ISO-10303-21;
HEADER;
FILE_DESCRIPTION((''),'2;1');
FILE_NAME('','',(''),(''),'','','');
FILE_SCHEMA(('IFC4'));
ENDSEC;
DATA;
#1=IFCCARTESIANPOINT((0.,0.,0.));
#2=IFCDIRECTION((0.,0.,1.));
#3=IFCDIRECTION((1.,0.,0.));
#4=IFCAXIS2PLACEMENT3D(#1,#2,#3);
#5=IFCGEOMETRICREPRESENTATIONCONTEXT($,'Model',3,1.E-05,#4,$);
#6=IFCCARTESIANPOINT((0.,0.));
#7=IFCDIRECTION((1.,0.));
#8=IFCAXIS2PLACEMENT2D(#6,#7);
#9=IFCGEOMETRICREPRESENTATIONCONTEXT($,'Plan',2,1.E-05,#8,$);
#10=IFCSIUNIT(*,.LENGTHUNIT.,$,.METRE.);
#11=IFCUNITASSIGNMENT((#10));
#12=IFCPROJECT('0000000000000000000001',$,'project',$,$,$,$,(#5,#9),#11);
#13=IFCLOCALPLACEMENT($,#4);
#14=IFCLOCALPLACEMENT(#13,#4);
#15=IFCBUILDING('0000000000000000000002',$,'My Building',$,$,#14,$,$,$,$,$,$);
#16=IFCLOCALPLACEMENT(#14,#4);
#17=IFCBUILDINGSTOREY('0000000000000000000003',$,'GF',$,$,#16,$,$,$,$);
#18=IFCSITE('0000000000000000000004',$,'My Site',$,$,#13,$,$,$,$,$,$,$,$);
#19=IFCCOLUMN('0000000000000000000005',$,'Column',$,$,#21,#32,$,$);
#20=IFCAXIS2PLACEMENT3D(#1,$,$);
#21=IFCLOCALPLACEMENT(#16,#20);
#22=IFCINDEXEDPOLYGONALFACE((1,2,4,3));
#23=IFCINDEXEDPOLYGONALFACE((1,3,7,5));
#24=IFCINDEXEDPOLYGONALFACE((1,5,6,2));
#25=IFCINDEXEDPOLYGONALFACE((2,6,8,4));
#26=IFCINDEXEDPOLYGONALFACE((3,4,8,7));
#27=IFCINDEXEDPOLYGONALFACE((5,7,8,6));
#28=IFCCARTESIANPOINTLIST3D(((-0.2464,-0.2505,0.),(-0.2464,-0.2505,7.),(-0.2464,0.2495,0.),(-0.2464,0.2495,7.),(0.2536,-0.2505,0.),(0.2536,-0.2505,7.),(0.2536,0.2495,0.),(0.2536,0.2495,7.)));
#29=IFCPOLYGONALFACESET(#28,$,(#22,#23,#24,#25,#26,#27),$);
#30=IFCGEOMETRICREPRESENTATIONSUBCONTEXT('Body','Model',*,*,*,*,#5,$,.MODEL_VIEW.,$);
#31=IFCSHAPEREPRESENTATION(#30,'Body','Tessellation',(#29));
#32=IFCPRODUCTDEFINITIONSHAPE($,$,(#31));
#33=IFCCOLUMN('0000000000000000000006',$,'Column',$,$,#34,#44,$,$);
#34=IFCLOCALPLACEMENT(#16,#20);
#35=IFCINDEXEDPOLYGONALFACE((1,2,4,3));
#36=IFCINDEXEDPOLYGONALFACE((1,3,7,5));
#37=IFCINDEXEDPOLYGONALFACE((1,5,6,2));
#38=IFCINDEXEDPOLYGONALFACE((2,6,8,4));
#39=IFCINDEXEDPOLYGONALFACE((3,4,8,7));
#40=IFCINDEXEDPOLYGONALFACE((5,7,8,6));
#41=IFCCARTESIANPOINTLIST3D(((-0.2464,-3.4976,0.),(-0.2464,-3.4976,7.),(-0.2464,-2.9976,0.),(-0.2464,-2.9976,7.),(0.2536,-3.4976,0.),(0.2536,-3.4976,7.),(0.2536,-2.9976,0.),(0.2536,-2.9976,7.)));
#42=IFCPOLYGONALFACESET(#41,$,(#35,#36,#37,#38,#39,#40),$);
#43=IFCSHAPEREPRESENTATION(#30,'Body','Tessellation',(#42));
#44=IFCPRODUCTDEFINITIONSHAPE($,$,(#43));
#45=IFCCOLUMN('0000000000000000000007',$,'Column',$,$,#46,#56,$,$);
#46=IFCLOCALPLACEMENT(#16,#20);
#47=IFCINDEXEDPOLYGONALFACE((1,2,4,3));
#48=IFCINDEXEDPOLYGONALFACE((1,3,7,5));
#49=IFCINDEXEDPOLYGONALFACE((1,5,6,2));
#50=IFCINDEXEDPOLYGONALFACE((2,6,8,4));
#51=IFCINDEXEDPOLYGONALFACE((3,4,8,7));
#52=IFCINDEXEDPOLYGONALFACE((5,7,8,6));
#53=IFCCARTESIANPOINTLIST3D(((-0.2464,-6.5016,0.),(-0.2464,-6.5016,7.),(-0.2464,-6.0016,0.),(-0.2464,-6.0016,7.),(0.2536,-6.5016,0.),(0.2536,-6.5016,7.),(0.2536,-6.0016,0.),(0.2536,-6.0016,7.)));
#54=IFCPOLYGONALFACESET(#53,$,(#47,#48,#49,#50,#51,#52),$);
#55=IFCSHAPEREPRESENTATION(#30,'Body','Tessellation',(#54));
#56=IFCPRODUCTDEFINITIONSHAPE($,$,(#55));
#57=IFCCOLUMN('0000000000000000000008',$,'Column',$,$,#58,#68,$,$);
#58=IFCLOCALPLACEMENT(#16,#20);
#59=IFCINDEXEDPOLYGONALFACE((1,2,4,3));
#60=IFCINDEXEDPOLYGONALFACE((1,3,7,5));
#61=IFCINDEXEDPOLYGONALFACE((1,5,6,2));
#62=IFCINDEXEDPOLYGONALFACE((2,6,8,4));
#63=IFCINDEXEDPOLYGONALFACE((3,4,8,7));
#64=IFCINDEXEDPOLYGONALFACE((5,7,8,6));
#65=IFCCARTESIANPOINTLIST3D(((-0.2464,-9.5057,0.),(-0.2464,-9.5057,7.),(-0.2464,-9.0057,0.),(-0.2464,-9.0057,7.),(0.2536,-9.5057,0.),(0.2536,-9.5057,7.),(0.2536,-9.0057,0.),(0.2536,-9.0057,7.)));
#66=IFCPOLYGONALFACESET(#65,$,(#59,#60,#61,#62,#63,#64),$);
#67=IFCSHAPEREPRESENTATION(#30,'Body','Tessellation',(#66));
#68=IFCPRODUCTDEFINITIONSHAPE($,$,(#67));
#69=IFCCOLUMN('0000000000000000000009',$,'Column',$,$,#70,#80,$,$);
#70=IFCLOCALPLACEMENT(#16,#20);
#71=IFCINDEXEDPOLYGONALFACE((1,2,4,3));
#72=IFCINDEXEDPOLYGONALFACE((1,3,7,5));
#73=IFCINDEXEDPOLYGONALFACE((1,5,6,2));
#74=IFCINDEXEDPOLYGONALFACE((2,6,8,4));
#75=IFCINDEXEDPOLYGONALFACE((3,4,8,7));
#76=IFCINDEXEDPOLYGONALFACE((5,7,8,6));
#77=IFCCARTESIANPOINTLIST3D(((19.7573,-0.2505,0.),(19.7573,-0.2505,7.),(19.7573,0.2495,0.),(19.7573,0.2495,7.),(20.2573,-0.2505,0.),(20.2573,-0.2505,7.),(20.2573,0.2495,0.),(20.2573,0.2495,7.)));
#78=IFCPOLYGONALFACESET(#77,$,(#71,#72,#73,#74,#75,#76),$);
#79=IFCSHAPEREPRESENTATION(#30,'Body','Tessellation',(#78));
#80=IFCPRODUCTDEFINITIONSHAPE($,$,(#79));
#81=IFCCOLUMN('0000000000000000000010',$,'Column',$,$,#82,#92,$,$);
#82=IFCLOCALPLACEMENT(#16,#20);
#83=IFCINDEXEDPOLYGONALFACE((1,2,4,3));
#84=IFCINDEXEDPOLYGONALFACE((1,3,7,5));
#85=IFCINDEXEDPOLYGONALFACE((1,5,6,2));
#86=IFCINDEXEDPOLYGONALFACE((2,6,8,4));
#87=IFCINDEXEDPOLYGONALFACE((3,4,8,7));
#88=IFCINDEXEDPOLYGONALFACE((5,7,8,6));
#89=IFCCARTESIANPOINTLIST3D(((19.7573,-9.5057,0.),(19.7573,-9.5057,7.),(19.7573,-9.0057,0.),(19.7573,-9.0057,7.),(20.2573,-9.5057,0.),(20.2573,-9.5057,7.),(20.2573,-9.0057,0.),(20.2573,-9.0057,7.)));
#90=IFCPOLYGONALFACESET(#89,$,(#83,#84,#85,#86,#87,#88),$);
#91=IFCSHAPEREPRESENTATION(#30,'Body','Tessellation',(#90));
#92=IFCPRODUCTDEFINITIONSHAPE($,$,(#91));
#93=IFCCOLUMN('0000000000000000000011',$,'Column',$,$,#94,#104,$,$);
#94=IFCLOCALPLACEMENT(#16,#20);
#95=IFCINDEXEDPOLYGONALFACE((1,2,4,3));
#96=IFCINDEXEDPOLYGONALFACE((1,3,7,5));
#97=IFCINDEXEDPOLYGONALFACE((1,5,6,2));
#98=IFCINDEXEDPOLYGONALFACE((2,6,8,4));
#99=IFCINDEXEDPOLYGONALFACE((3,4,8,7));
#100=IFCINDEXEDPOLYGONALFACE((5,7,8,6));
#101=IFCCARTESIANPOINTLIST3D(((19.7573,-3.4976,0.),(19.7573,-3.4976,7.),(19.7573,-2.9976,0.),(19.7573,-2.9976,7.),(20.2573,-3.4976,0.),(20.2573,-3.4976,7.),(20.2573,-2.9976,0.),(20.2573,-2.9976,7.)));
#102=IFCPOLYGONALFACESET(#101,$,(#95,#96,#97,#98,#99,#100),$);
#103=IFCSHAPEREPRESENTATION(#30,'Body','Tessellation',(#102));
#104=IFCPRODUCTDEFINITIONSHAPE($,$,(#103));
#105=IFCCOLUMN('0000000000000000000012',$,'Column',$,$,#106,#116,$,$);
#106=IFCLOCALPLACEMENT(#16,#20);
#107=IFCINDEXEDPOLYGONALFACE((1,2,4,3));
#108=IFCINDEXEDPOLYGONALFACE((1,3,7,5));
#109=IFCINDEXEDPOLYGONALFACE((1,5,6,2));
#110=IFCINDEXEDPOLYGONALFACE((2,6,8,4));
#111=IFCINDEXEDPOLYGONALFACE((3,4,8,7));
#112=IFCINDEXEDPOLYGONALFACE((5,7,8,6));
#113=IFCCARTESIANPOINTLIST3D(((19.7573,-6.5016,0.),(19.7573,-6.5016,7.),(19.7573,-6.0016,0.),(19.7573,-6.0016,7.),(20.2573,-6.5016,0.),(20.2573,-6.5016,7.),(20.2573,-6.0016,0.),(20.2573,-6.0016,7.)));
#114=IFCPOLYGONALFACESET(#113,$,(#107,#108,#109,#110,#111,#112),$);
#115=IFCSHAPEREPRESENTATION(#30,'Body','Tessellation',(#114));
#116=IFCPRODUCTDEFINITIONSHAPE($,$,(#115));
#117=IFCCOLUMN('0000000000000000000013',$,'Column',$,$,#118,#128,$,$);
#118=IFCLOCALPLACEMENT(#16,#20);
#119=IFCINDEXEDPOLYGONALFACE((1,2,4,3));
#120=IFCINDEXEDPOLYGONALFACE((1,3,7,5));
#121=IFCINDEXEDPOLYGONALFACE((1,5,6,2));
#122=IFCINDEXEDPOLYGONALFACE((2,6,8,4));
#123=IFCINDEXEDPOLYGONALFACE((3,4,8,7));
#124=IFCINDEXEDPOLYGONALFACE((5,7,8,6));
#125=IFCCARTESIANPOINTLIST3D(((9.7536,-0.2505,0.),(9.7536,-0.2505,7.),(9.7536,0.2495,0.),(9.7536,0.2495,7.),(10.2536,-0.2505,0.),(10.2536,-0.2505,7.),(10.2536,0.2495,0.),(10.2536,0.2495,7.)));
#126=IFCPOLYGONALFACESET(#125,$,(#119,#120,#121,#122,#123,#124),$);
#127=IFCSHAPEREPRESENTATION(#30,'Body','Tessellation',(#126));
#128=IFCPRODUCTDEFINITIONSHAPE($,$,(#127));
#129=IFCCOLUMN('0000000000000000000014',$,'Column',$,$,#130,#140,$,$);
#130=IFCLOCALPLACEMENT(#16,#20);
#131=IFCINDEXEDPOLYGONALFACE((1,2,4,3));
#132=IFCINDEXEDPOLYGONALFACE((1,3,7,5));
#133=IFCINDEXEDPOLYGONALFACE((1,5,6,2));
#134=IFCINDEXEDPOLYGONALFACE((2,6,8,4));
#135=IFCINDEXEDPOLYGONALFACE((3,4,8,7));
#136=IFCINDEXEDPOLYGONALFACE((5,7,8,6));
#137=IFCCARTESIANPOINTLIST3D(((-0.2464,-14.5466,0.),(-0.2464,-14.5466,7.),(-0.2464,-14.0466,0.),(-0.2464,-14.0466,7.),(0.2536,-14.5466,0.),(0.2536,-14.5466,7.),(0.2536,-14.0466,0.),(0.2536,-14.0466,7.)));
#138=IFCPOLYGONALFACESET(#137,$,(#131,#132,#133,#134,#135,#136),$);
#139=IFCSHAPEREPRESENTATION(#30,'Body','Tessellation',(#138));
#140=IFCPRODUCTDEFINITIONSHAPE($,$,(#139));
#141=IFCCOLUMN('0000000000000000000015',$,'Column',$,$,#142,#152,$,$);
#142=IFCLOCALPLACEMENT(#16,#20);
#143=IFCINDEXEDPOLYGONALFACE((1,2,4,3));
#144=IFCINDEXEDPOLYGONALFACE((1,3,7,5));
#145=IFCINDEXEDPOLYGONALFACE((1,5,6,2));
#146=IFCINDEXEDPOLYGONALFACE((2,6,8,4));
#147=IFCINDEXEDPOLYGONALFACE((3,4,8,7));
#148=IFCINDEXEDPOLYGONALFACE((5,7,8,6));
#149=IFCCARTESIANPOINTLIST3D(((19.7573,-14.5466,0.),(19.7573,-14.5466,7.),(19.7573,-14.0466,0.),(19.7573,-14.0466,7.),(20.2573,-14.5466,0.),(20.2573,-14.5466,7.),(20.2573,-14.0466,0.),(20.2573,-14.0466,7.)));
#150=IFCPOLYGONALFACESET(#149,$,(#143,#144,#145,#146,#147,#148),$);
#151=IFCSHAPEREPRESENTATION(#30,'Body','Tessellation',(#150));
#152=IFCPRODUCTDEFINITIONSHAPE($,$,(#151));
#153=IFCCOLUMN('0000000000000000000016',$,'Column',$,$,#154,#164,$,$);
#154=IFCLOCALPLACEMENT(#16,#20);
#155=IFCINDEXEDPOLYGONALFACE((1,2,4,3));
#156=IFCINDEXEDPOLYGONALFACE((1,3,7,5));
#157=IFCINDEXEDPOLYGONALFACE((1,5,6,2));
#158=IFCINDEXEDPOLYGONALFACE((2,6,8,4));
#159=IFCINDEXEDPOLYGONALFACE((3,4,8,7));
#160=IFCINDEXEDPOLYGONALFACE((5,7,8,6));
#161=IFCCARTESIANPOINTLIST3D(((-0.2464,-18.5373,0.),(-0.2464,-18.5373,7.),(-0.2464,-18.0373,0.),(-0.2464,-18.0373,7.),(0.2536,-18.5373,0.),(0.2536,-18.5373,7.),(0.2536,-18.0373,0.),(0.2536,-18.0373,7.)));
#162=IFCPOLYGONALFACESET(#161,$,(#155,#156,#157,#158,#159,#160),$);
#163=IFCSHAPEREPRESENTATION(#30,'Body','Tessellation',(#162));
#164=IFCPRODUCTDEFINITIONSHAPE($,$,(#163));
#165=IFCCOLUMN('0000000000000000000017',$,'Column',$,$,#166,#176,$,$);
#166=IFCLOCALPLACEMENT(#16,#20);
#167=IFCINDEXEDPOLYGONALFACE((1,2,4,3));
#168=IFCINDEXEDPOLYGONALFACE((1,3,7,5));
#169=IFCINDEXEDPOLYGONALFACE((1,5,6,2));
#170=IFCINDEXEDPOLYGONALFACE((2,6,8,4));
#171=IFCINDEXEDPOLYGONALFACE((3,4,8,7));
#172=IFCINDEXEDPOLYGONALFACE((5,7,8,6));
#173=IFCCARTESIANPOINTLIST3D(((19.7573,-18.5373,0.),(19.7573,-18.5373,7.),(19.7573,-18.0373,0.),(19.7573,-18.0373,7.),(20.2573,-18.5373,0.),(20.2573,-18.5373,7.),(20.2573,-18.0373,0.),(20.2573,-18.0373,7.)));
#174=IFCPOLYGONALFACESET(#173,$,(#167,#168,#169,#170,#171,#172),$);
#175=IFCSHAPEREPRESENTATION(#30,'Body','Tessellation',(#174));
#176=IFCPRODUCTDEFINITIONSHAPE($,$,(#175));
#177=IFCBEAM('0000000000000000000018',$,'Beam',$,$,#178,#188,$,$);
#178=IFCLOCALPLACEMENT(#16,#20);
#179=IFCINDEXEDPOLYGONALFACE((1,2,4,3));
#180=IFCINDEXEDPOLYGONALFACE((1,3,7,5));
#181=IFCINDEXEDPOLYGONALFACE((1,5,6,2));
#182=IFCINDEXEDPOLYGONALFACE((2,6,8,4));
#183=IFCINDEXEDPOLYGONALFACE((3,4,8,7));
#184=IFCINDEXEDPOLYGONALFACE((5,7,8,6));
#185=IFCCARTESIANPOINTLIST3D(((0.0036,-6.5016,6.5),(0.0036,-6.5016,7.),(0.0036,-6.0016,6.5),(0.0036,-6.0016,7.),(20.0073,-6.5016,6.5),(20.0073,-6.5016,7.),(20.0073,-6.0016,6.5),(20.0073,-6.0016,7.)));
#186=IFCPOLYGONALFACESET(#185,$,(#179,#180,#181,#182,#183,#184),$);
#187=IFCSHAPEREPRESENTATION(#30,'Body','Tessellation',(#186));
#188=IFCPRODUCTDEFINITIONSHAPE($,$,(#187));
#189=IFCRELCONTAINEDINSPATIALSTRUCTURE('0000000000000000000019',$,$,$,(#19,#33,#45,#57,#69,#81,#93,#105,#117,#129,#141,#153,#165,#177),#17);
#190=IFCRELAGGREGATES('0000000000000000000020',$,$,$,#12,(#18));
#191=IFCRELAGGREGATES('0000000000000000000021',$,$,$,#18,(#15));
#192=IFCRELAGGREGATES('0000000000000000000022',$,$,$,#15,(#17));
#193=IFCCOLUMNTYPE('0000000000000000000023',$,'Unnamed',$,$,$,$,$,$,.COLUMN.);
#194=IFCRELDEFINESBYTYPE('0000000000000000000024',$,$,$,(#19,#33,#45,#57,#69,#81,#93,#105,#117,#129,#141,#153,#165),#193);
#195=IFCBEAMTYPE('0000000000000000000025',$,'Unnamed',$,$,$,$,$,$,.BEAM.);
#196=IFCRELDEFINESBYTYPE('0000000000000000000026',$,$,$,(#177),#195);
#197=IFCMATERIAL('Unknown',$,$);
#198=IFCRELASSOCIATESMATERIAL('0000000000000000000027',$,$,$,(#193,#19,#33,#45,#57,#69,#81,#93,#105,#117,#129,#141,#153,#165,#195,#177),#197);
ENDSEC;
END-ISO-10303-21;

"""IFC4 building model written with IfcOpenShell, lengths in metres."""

from ifc_helpers import new_model, si_unit, frame, origin_with_axes, origin_2d_with_axis, place, context, subcontext, project, spatial, rectangle, extrude, material, material_profile, profile_set, profile_usage, type_object, element, save


model = new_model("IFC4")

# Units and contexts
model_context = context("Model", 3, precision=1e-05, world=origin_with_axes())
plan_context = context("Plan", 2, precision=1e-05, world=origin_2d_with_axis())
body_context_1 = subcontext(model_context, "Body", "Model", "MODEL_VIEW")
ifc_project = project(units=[si_unit("LENGTHUNIT", "METRE")], contexts=[model_context, plan_context])

# Site, building, storey
site_placement = place(None, origin_with_axes())
site = spatial("IfcSite", under=ifc_project, at=site_placement, Name="My Site")
building_placement = place(site_placement, origin_with_axes())
building = spatial("IfcBuilding", under=site, at=building_placement, Name="My Building")
storey_placement = place(building_placement, origin_with_axes())
storey = spatial("IfcBuildingStorey", under=building, at=storey_placement, Name="GF")

# Columns
ifc_material = material(Name="Unknown")
ifc_material_profile_1 = material_profile(ifc_material, rectangle(XDim=0.5, YDim=0.5))
ifc_profile_set_1 = profile_set([ifc_material_profile_1])
ifc_profile_usage_1 = profile_usage(ifc_profile_set_1, cardinal=5)
column_type = type_object("IfcColumnType", Name="Unnamed", PredefinedType="COLUMN", material=ifc_profile_set_1)
column_1_placement = place(storey_placement, frame((0.0036, -0.0005, 0.0), z_axis=(0.0, 0.0, 1.0), x_axis=(1.0, 0.0, 0.0)))
element("IfcColumn", 1, at=column_1_placement, inside=storey, type_object=column_type, material=ifc_profile_usage_1, Name="Column", context=body_context_1, shape_type="SweptSolid", body=[
    extrude(rectangle(XDim=0.5, YDim=0.5), origin_with_axes(), (0.0, 0.0, 1.0), 7.0),
])
ifc_profile_usage_2 = profile_usage(ifc_profile_set_1, cardinal=5)
column_2_placement = place(storey_placement, frame((0.0036, -3.2476, 0.0), z_axis=(0.0, 0.0, 1.0), x_axis=(1.0, 0.0, 0.0)))
element("IfcColumn", 2, at=column_2_placement, inside=storey, type_object=column_type, material=ifc_profile_usage_2, Name="Column", context=body_context_1, shape_type="SweptSolid", body=[
    extrude(rectangle(XDim=0.5, YDim=0.5), origin_with_axes(), (0.0, 0.0, 1.0), 7.0),
])
ifc_profile_usage_3 = profile_usage(ifc_profile_set_1, cardinal=5)
column_3_placement = place(storey_placement, frame((0.0036, -6.2516, 0.0), z_axis=(0.0, 0.0, 1.0), x_axis=(1.0, 0.0, 0.0)))
element("IfcColumn", 3, at=column_3_placement, inside=storey, type_object=column_type, material=ifc_profile_usage_3, Name="Column", context=body_context_1, shape_type="SweptSolid", body=[
    extrude(rectangle(XDim=0.5, YDim=0.5), origin_with_axes(), (0.0, 0.0, 1.0), 7.0),
])
ifc_profile_usage_4 = profile_usage(ifc_profile_set_1, cardinal=5)
column_4_placement = place(storey_placement, frame((0.0036, -9.2557, 0.0), z_axis=(0.0, 0.0, 1.0), x_axis=(1.0, 0.0, 0.0)))
element("IfcColumn", 4, at=column_4_placement, inside=storey, type_object=column_type, material=ifc_profile_usage_4, Name="Column", context=body_context_1, shape_type="SweptSolid", body=[
    extrude(rectangle(XDim=0.5, YDim=0.5), origin_with_axes(), (0.0, 0.0, 1.0), 7.0),
])
ifc_profile_usage_5 = profile_usage(ifc_profile_set_1, cardinal=5)
column_5_placement = place(storey_placement, frame((20.0073, -0.0005, 0.0), z_axis=(0.0, 0.0, 1.0), x_axis=(1.0, 0.0, 0.0)))
element("IfcColumn", 5, at=column_5_placement, inside=storey, type_object=column_type, material=ifc_profile_usage_5, Name="Column", context=body_context_1, shape_type="SweptSolid", body=[
    extrude(rectangle(XDim=0.5, YDim=0.5), origin_with_axes(), (0.0, 0.0, 1.0), 7.0),
])
ifc_profile_usage_6 = profile_usage(ifc_profile_set_1, cardinal=5)
column_6_placement = place(storey_placement, frame((20.0073, -9.2557, 0.0), z_axis=(0.0, 0.0, 1.0), x_axis=(1.0, 0.0, 0.0)))
element("IfcColumn", 6, at=column_6_placement, inside=storey, type_object=column_type, material=ifc_profile_usage_6, Name="Column", context=body_context_1, shape_type="SweptSolid", body=[
    extrude(rectangle(XDim=0.5, YDim=0.5), origin_with_axes(), (0.0, 0.0, 1.0), 7.0),
])
ifc_profile_usage_7 = profile_usage(ifc_profile_set_1, cardinal=5)
column_7_placement = place(storey_placement, frame((20.0073, -3.2476, 0.0), z_axis=(0.0, 0.0, 1.0), x_axis=(1.0, 0.0, 0.0)))
element("IfcColumn", 7, at=column_7_placement, inside=storey, type_object=column_type, material=ifc_profile_usage_7, Name="Column", context=body_context_1, shape_type="SweptSolid", body=[
    extrude(rectangle(XDim=0.5, YDim=0.5), origin_with_axes(), (0.0, 0.0, 1.0), 7.0),
])
ifc_profile_usage_8 = profile_usage(ifc_profile_set_1, cardinal=5)
column_8_placement = place(storey_placement, frame((20.0073, -6.2516, 0.0), z_axis=(0.0, 0.0, 1.0), x_axis=(1.0, 0.0, 0.0)))
element("IfcColumn", 8, at=column_8_placement, inside=storey, type_object=column_type, material=ifc_profile_usage_8, Name="Column", context=body_context_1, shape_type="SweptSolid", body=[
    extrude(rectangle(XDim=0.5, YDim=0.5), origin_with_axes(), (0.0, 0.0, 1.0), 7.0),
])
ifc_profile_usage_9 = profile_usage(ifc_profile_set_1, cardinal=5)
column_9_placement = place(storey_placement, frame((10.0036, -0.0005, 0.0), z_axis=(0.0, 0.0, 1.0), x_axis=(1.0, 0.0, 0.0)))
element("IfcColumn", 9, at=column_9_placement, inside=storey, type_object=column_type, material=ifc_profile_usage_9, Name="Column", context=body_context_1, shape_type="SweptSolid", body=[
    extrude(rectangle(XDim=0.5, YDim=0.5), origin_with_axes(), (0.0, 0.0, 1.0), 7.0),
])
ifc_profile_usage_10 = profile_usage(ifc_profile_set_1, cardinal=5)
column_10_placement = place(storey_placement, frame((0.0036, -14.2966, 0.0), z_axis=(0.0, 0.0, 1.0), x_axis=(1.0, 0.0, 0.0)))
element("IfcColumn", 10, at=column_10_placement, inside=storey, type_object=column_type, material=ifc_profile_usage_10, Name="Column", context=body_context_1, shape_type="SweptSolid", body=[
    extrude(rectangle(XDim=0.5, YDim=0.5), origin_with_axes(), (0.0, 0.0, 1.0), 7.0),
])
ifc_profile_usage_11 = profile_usage(ifc_profile_set_1, cardinal=5)
column_11_placement = place(storey_placement, frame((20.0073, -14.2966, 0.0), z_axis=(0.0, 0.0, 1.0), x_axis=(1.0, 0.0, 0.0)))
element("IfcColumn", 11, at=column_11_placement, inside=storey, type_object=column_type, material=ifc_profile_usage_11, Name="Column", context=body_context_1, shape_type="SweptSolid", body=[
    extrude(rectangle(XDim=0.5, YDim=0.5), origin_with_axes(), (0.0, 0.0, 1.0), 7.0),
])
ifc_profile_usage_12 = profile_usage(ifc_profile_set_1, cardinal=5)
column_12_placement = place(storey_placement, frame((0.0036, -18.2873, 0.0), z_axis=(0.0, 0.0, 1.0), x_axis=(1.0, 0.0, 0.0)))
element("IfcColumn", 12, at=column_12_placement, inside=storey, type_object=column_type, material=ifc_profile_usage_12, Name="Column", context=body_context_1, shape_type="SweptSolid", body=[
    extrude(rectangle(XDim=0.5, YDim=0.5), origin_with_axes(), (0.0, 0.0, 1.0), 7.0),
])
ifc_profile_usage_13 = profile_usage(ifc_profile_set_1, cardinal=5)
column_13_placement = place(storey_placement, frame((20.0073, -18.2873, 0.0), z_axis=(0.0, 0.0, 1.0), x_axis=(1.0, 0.0, 0.0)))
element("IfcColumn", 13, at=column_13_placement, inside=storey, type_object=column_type, material=ifc_profile_usage_13, Name="Column", context=body_context_1, shape_type="SweptSolid", body=[
    extrude(rectangle(XDim=0.5, YDim=0.5), origin_with_axes(), (0.0, 0.0, 1.0), 7.0),
])

# Beam
ifc_material_profile_2 = material_profile(ifc_material, rectangle(XDim=0.5, YDim=0.5))
ifc_profile_set_2 = profile_set([ifc_material_profile_2])
ifc_profile_usage_14 = profile_usage(ifc_profile_set_2, cardinal=5)
beam_type = type_object("IfcBeamType", Name="Unnamed", PredefinedType="BEAM", material=ifc_profile_set_2)
beam_1_placement = place(storey_placement, frame((0.0036, -6.2516, 6.75), z_axis=(1.0, 0.0, 0.0), x_axis=(0.0, 1.0, 0.0)))
element("IfcBeam", 14, at=beam_1_placement, inside=storey, type_object=beam_type, material=ifc_profile_usage_14, Name="Beam", context=body_context_1, shape_type="SweptSolid", body=[
    extrude(rectangle(XDim=0.5, YDim=0.5), origin_with_axes(), (0.0, 0.0, 1.0), 20.0037),
])

save(model, "model.ifc")
